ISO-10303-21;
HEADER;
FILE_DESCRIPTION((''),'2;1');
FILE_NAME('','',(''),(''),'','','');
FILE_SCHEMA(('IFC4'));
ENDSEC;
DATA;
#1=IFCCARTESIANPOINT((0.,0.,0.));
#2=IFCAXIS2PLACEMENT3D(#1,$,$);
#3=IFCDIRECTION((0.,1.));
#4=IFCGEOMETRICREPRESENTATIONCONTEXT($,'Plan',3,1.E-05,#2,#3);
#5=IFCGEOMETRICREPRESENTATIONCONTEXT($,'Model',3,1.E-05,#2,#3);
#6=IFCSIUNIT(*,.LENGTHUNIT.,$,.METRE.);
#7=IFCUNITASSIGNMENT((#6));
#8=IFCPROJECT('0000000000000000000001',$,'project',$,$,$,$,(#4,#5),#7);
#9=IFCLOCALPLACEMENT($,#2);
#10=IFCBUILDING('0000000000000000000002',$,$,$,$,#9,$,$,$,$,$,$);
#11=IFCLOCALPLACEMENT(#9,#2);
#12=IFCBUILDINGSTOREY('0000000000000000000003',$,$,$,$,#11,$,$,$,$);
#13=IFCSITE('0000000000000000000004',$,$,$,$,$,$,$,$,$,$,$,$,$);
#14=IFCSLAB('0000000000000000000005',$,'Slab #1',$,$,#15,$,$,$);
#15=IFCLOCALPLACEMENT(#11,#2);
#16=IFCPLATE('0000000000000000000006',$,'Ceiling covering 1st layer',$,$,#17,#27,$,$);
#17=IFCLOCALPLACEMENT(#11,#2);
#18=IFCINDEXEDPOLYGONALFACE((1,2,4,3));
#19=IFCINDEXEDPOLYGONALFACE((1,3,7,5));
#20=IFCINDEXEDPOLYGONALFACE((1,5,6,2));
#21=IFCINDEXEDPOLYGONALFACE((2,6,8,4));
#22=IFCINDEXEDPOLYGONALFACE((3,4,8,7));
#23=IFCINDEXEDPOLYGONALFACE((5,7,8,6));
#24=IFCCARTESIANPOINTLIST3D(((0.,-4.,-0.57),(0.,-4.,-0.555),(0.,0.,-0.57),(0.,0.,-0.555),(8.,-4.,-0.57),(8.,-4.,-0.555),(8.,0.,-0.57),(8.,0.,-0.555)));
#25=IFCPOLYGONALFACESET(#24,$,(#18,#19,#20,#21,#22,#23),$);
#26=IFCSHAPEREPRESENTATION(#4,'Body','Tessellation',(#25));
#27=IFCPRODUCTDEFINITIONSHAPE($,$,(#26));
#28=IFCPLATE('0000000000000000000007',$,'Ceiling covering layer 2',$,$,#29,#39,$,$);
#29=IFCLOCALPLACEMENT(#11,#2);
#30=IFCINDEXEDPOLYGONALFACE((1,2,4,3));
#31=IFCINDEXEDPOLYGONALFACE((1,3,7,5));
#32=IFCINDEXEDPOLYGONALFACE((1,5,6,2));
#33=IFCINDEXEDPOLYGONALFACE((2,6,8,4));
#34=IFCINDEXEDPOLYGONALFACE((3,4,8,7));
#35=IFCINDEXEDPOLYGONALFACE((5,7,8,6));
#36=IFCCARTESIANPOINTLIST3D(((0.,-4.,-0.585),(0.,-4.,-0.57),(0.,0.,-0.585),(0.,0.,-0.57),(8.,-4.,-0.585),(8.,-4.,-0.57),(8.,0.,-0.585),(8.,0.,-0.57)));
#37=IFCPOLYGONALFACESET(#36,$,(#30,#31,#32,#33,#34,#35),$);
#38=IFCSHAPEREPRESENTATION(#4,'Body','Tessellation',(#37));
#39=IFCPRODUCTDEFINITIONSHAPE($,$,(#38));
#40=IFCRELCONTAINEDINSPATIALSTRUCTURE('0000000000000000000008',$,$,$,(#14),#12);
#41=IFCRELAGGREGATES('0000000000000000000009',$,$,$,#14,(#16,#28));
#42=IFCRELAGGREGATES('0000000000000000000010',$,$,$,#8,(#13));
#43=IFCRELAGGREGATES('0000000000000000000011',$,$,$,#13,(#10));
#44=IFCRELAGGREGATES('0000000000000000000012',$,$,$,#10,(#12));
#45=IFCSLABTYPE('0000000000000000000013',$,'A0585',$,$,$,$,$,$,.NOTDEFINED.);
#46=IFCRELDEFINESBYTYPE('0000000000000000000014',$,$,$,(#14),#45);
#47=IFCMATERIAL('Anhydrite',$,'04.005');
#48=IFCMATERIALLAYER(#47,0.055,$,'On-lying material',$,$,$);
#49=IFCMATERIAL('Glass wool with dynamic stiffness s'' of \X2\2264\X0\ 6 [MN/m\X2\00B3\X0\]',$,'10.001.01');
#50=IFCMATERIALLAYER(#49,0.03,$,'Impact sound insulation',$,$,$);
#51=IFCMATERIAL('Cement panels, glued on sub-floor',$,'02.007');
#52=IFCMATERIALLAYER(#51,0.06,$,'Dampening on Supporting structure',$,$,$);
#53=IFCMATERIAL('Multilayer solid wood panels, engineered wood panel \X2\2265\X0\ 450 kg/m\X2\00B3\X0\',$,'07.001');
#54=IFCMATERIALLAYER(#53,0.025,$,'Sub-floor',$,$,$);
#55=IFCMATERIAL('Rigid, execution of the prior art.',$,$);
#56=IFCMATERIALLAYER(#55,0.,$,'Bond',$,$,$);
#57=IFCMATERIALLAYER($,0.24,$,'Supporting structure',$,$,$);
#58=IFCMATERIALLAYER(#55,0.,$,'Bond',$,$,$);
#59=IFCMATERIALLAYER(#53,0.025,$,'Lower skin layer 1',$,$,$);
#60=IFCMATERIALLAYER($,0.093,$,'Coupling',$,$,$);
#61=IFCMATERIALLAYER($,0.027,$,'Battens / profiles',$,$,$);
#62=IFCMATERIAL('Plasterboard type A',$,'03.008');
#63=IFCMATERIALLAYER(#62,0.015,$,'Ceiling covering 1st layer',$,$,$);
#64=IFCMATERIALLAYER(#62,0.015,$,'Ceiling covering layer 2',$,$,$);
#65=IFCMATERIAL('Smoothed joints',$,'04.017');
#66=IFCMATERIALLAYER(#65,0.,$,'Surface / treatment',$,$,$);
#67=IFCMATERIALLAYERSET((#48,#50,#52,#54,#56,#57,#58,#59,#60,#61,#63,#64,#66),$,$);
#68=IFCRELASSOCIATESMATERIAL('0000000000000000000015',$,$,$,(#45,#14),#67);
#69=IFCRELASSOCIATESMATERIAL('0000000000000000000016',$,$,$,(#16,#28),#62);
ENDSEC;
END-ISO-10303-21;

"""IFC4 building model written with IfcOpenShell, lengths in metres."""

from ifc_helpers import new_model, si_unit, direction, frame, frame_2d, origin, place, context, project, spatial, rectangle, extrude, material, layer, layer_set, type_object, element, aggregate, save


model = new_model("IFC4")

# Units and contexts
plan_context = context("Plan", 3, precision=1e-05, world=origin(), true_north=direction((0.0, 1.0)))
model_context = context("Model", 3, precision=1e-05, world=origin(), true_north=direction((0.0, 1.0)))
ifc_project = project(units=[si_unit("LENGTHUNIT", "METRE")], contexts=[plan_context, model_context])

# Site, building, storey
site = spatial("IfcSite", under=ifc_project)
building_placement = place(None, origin())
building = spatial("IfcBuilding", under=site, at=building_placement)
storey_placement = place(building_placement, origin())
storey = spatial("IfcBuildingStorey", under=building, at=storey_placement)

# Slab, plates
ifc_material_1 = material(Name="Anhydrite", Category="04.005")
ifc_layer_1 = layer(ifc_material_1, 0.055, Name="On-lying material")
ifc_material_2 = material(Name="Glass wool with dynamic stiffness s' of ≤ 6 [MN/m³]", Category="10.001.01")
ifc_layer_2 = layer(ifc_material_2, 0.03, Name="Impact sound insulation")
ifc_material_3 = material(Name="Cement panels, glued on sub-floor", Category="02.007")
ifc_layer_3 = layer(ifc_material_3, 0.06, Name="Dampening on Supporting structure")
ifc_material_4 = material(Name="Multilayer solid wood panels, engineered wood panel ≥ 450 kg/m³", Category="07.001")
ifc_layer_4 = layer(ifc_material_4, 0.025, Name="Sub-floor")
ifc_material_5 = material(Name="Rigid, execution of the prior art.")
ifc_layer_5 = layer(ifc_material_5, 0.0, Name="Bond")
ifc_layer_6 = layer(None, 0.24, Name="Supporting structure")
ifc_layer_7 = layer(ifc_material_5, 0.0, Name="Bond")
ifc_layer_8 = layer(ifc_material_4, 0.025, Name="Lower skin layer 1")
ifc_layer_9 = layer(None, 0.093, Name="Coupling")
ifc_layer_10 = layer(None, 0.027, Name="Battens / profiles")
ifc_material_6 = material(Name="Plasterboard type A", Category="03.008")
ifc_layer_11 = layer(ifc_material_6, 0.015, Name="Ceiling covering 1st layer")
ifc_layer_12 = layer(ifc_material_6, 0.015, Name="Ceiling covering layer 2")
ifc_material_7 = material(Name="Smoothed joints", Category="04.017")
ifc_layer_13 = layer(ifc_material_7, 0.0, Name="Surface / treatment")
ifc_layer_set = layer_set([ifc_layer_1, ifc_layer_2, ifc_layer_3, ifc_layer_4, ifc_layer_5, ifc_layer_6, ifc_layer_7, ifc_layer_8, ifc_layer_9, ifc_layer_10, ifc_layer_11, ifc_layer_12, ifc_layer_13])
slab_type = type_object("IfcSlabType", Name="A0585", PredefinedType="NOTDEFINED", material=ifc_layer_set)
slab_placement = place(None, frame((0.0, 0.0, 0.0), z_axis=(0.0, 0.0, -1.0), x_axis=(1.0, 0.0, 0.0)))
slab = element("IfcSlab", 1, at=slab_placement, inside=storey, type_object=slab_type, material=ifc_layer_set, Name="Slab #1")
plate_1_placement = place(slab_placement, origin())
plate_1 = element("IfcPlate", 2, at=plate_1_placement, material=ifc_material_6, Name="Ceiling covering 1st layer", context=plan_context, shape_type="SweptSolid", body=[
    extrude(rectangle(XDim=8.0, YDim=4.0, at=frame_2d((4.0, 2.0), x_axis=(1.0, 0.0))), frame((0.0, 0.0, 0.555), z_axis=(0.0, 0.0, 1.0), x_axis=(1.0, 0.0, 0.0)), (0.0, 0.0, 1.0), 0.015),
])
plate_2_placement = place(slab_placement, origin())
plate_2 = element("IfcPlate", 3, at=plate_2_placement, material=ifc_material_6, Name="Ceiling covering layer 2", context=plan_context, shape_type="SweptSolid", body=[
    extrude(rectangle(XDim=8.0, YDim=4.0, at=frame_2d((4.0, 2.0), x_axis=(1.0, 0.0))), frame((0.0, 0.0, 0.57), z_axis=(0.0, 0.0, 1.0), x_axis=(1.0, 0.0, 0.0)), (0.0, 0.0, 1.0), 0.015),
])
aggregate(slab, [plate_1, plate_2])

save(model, "model.ifc")
